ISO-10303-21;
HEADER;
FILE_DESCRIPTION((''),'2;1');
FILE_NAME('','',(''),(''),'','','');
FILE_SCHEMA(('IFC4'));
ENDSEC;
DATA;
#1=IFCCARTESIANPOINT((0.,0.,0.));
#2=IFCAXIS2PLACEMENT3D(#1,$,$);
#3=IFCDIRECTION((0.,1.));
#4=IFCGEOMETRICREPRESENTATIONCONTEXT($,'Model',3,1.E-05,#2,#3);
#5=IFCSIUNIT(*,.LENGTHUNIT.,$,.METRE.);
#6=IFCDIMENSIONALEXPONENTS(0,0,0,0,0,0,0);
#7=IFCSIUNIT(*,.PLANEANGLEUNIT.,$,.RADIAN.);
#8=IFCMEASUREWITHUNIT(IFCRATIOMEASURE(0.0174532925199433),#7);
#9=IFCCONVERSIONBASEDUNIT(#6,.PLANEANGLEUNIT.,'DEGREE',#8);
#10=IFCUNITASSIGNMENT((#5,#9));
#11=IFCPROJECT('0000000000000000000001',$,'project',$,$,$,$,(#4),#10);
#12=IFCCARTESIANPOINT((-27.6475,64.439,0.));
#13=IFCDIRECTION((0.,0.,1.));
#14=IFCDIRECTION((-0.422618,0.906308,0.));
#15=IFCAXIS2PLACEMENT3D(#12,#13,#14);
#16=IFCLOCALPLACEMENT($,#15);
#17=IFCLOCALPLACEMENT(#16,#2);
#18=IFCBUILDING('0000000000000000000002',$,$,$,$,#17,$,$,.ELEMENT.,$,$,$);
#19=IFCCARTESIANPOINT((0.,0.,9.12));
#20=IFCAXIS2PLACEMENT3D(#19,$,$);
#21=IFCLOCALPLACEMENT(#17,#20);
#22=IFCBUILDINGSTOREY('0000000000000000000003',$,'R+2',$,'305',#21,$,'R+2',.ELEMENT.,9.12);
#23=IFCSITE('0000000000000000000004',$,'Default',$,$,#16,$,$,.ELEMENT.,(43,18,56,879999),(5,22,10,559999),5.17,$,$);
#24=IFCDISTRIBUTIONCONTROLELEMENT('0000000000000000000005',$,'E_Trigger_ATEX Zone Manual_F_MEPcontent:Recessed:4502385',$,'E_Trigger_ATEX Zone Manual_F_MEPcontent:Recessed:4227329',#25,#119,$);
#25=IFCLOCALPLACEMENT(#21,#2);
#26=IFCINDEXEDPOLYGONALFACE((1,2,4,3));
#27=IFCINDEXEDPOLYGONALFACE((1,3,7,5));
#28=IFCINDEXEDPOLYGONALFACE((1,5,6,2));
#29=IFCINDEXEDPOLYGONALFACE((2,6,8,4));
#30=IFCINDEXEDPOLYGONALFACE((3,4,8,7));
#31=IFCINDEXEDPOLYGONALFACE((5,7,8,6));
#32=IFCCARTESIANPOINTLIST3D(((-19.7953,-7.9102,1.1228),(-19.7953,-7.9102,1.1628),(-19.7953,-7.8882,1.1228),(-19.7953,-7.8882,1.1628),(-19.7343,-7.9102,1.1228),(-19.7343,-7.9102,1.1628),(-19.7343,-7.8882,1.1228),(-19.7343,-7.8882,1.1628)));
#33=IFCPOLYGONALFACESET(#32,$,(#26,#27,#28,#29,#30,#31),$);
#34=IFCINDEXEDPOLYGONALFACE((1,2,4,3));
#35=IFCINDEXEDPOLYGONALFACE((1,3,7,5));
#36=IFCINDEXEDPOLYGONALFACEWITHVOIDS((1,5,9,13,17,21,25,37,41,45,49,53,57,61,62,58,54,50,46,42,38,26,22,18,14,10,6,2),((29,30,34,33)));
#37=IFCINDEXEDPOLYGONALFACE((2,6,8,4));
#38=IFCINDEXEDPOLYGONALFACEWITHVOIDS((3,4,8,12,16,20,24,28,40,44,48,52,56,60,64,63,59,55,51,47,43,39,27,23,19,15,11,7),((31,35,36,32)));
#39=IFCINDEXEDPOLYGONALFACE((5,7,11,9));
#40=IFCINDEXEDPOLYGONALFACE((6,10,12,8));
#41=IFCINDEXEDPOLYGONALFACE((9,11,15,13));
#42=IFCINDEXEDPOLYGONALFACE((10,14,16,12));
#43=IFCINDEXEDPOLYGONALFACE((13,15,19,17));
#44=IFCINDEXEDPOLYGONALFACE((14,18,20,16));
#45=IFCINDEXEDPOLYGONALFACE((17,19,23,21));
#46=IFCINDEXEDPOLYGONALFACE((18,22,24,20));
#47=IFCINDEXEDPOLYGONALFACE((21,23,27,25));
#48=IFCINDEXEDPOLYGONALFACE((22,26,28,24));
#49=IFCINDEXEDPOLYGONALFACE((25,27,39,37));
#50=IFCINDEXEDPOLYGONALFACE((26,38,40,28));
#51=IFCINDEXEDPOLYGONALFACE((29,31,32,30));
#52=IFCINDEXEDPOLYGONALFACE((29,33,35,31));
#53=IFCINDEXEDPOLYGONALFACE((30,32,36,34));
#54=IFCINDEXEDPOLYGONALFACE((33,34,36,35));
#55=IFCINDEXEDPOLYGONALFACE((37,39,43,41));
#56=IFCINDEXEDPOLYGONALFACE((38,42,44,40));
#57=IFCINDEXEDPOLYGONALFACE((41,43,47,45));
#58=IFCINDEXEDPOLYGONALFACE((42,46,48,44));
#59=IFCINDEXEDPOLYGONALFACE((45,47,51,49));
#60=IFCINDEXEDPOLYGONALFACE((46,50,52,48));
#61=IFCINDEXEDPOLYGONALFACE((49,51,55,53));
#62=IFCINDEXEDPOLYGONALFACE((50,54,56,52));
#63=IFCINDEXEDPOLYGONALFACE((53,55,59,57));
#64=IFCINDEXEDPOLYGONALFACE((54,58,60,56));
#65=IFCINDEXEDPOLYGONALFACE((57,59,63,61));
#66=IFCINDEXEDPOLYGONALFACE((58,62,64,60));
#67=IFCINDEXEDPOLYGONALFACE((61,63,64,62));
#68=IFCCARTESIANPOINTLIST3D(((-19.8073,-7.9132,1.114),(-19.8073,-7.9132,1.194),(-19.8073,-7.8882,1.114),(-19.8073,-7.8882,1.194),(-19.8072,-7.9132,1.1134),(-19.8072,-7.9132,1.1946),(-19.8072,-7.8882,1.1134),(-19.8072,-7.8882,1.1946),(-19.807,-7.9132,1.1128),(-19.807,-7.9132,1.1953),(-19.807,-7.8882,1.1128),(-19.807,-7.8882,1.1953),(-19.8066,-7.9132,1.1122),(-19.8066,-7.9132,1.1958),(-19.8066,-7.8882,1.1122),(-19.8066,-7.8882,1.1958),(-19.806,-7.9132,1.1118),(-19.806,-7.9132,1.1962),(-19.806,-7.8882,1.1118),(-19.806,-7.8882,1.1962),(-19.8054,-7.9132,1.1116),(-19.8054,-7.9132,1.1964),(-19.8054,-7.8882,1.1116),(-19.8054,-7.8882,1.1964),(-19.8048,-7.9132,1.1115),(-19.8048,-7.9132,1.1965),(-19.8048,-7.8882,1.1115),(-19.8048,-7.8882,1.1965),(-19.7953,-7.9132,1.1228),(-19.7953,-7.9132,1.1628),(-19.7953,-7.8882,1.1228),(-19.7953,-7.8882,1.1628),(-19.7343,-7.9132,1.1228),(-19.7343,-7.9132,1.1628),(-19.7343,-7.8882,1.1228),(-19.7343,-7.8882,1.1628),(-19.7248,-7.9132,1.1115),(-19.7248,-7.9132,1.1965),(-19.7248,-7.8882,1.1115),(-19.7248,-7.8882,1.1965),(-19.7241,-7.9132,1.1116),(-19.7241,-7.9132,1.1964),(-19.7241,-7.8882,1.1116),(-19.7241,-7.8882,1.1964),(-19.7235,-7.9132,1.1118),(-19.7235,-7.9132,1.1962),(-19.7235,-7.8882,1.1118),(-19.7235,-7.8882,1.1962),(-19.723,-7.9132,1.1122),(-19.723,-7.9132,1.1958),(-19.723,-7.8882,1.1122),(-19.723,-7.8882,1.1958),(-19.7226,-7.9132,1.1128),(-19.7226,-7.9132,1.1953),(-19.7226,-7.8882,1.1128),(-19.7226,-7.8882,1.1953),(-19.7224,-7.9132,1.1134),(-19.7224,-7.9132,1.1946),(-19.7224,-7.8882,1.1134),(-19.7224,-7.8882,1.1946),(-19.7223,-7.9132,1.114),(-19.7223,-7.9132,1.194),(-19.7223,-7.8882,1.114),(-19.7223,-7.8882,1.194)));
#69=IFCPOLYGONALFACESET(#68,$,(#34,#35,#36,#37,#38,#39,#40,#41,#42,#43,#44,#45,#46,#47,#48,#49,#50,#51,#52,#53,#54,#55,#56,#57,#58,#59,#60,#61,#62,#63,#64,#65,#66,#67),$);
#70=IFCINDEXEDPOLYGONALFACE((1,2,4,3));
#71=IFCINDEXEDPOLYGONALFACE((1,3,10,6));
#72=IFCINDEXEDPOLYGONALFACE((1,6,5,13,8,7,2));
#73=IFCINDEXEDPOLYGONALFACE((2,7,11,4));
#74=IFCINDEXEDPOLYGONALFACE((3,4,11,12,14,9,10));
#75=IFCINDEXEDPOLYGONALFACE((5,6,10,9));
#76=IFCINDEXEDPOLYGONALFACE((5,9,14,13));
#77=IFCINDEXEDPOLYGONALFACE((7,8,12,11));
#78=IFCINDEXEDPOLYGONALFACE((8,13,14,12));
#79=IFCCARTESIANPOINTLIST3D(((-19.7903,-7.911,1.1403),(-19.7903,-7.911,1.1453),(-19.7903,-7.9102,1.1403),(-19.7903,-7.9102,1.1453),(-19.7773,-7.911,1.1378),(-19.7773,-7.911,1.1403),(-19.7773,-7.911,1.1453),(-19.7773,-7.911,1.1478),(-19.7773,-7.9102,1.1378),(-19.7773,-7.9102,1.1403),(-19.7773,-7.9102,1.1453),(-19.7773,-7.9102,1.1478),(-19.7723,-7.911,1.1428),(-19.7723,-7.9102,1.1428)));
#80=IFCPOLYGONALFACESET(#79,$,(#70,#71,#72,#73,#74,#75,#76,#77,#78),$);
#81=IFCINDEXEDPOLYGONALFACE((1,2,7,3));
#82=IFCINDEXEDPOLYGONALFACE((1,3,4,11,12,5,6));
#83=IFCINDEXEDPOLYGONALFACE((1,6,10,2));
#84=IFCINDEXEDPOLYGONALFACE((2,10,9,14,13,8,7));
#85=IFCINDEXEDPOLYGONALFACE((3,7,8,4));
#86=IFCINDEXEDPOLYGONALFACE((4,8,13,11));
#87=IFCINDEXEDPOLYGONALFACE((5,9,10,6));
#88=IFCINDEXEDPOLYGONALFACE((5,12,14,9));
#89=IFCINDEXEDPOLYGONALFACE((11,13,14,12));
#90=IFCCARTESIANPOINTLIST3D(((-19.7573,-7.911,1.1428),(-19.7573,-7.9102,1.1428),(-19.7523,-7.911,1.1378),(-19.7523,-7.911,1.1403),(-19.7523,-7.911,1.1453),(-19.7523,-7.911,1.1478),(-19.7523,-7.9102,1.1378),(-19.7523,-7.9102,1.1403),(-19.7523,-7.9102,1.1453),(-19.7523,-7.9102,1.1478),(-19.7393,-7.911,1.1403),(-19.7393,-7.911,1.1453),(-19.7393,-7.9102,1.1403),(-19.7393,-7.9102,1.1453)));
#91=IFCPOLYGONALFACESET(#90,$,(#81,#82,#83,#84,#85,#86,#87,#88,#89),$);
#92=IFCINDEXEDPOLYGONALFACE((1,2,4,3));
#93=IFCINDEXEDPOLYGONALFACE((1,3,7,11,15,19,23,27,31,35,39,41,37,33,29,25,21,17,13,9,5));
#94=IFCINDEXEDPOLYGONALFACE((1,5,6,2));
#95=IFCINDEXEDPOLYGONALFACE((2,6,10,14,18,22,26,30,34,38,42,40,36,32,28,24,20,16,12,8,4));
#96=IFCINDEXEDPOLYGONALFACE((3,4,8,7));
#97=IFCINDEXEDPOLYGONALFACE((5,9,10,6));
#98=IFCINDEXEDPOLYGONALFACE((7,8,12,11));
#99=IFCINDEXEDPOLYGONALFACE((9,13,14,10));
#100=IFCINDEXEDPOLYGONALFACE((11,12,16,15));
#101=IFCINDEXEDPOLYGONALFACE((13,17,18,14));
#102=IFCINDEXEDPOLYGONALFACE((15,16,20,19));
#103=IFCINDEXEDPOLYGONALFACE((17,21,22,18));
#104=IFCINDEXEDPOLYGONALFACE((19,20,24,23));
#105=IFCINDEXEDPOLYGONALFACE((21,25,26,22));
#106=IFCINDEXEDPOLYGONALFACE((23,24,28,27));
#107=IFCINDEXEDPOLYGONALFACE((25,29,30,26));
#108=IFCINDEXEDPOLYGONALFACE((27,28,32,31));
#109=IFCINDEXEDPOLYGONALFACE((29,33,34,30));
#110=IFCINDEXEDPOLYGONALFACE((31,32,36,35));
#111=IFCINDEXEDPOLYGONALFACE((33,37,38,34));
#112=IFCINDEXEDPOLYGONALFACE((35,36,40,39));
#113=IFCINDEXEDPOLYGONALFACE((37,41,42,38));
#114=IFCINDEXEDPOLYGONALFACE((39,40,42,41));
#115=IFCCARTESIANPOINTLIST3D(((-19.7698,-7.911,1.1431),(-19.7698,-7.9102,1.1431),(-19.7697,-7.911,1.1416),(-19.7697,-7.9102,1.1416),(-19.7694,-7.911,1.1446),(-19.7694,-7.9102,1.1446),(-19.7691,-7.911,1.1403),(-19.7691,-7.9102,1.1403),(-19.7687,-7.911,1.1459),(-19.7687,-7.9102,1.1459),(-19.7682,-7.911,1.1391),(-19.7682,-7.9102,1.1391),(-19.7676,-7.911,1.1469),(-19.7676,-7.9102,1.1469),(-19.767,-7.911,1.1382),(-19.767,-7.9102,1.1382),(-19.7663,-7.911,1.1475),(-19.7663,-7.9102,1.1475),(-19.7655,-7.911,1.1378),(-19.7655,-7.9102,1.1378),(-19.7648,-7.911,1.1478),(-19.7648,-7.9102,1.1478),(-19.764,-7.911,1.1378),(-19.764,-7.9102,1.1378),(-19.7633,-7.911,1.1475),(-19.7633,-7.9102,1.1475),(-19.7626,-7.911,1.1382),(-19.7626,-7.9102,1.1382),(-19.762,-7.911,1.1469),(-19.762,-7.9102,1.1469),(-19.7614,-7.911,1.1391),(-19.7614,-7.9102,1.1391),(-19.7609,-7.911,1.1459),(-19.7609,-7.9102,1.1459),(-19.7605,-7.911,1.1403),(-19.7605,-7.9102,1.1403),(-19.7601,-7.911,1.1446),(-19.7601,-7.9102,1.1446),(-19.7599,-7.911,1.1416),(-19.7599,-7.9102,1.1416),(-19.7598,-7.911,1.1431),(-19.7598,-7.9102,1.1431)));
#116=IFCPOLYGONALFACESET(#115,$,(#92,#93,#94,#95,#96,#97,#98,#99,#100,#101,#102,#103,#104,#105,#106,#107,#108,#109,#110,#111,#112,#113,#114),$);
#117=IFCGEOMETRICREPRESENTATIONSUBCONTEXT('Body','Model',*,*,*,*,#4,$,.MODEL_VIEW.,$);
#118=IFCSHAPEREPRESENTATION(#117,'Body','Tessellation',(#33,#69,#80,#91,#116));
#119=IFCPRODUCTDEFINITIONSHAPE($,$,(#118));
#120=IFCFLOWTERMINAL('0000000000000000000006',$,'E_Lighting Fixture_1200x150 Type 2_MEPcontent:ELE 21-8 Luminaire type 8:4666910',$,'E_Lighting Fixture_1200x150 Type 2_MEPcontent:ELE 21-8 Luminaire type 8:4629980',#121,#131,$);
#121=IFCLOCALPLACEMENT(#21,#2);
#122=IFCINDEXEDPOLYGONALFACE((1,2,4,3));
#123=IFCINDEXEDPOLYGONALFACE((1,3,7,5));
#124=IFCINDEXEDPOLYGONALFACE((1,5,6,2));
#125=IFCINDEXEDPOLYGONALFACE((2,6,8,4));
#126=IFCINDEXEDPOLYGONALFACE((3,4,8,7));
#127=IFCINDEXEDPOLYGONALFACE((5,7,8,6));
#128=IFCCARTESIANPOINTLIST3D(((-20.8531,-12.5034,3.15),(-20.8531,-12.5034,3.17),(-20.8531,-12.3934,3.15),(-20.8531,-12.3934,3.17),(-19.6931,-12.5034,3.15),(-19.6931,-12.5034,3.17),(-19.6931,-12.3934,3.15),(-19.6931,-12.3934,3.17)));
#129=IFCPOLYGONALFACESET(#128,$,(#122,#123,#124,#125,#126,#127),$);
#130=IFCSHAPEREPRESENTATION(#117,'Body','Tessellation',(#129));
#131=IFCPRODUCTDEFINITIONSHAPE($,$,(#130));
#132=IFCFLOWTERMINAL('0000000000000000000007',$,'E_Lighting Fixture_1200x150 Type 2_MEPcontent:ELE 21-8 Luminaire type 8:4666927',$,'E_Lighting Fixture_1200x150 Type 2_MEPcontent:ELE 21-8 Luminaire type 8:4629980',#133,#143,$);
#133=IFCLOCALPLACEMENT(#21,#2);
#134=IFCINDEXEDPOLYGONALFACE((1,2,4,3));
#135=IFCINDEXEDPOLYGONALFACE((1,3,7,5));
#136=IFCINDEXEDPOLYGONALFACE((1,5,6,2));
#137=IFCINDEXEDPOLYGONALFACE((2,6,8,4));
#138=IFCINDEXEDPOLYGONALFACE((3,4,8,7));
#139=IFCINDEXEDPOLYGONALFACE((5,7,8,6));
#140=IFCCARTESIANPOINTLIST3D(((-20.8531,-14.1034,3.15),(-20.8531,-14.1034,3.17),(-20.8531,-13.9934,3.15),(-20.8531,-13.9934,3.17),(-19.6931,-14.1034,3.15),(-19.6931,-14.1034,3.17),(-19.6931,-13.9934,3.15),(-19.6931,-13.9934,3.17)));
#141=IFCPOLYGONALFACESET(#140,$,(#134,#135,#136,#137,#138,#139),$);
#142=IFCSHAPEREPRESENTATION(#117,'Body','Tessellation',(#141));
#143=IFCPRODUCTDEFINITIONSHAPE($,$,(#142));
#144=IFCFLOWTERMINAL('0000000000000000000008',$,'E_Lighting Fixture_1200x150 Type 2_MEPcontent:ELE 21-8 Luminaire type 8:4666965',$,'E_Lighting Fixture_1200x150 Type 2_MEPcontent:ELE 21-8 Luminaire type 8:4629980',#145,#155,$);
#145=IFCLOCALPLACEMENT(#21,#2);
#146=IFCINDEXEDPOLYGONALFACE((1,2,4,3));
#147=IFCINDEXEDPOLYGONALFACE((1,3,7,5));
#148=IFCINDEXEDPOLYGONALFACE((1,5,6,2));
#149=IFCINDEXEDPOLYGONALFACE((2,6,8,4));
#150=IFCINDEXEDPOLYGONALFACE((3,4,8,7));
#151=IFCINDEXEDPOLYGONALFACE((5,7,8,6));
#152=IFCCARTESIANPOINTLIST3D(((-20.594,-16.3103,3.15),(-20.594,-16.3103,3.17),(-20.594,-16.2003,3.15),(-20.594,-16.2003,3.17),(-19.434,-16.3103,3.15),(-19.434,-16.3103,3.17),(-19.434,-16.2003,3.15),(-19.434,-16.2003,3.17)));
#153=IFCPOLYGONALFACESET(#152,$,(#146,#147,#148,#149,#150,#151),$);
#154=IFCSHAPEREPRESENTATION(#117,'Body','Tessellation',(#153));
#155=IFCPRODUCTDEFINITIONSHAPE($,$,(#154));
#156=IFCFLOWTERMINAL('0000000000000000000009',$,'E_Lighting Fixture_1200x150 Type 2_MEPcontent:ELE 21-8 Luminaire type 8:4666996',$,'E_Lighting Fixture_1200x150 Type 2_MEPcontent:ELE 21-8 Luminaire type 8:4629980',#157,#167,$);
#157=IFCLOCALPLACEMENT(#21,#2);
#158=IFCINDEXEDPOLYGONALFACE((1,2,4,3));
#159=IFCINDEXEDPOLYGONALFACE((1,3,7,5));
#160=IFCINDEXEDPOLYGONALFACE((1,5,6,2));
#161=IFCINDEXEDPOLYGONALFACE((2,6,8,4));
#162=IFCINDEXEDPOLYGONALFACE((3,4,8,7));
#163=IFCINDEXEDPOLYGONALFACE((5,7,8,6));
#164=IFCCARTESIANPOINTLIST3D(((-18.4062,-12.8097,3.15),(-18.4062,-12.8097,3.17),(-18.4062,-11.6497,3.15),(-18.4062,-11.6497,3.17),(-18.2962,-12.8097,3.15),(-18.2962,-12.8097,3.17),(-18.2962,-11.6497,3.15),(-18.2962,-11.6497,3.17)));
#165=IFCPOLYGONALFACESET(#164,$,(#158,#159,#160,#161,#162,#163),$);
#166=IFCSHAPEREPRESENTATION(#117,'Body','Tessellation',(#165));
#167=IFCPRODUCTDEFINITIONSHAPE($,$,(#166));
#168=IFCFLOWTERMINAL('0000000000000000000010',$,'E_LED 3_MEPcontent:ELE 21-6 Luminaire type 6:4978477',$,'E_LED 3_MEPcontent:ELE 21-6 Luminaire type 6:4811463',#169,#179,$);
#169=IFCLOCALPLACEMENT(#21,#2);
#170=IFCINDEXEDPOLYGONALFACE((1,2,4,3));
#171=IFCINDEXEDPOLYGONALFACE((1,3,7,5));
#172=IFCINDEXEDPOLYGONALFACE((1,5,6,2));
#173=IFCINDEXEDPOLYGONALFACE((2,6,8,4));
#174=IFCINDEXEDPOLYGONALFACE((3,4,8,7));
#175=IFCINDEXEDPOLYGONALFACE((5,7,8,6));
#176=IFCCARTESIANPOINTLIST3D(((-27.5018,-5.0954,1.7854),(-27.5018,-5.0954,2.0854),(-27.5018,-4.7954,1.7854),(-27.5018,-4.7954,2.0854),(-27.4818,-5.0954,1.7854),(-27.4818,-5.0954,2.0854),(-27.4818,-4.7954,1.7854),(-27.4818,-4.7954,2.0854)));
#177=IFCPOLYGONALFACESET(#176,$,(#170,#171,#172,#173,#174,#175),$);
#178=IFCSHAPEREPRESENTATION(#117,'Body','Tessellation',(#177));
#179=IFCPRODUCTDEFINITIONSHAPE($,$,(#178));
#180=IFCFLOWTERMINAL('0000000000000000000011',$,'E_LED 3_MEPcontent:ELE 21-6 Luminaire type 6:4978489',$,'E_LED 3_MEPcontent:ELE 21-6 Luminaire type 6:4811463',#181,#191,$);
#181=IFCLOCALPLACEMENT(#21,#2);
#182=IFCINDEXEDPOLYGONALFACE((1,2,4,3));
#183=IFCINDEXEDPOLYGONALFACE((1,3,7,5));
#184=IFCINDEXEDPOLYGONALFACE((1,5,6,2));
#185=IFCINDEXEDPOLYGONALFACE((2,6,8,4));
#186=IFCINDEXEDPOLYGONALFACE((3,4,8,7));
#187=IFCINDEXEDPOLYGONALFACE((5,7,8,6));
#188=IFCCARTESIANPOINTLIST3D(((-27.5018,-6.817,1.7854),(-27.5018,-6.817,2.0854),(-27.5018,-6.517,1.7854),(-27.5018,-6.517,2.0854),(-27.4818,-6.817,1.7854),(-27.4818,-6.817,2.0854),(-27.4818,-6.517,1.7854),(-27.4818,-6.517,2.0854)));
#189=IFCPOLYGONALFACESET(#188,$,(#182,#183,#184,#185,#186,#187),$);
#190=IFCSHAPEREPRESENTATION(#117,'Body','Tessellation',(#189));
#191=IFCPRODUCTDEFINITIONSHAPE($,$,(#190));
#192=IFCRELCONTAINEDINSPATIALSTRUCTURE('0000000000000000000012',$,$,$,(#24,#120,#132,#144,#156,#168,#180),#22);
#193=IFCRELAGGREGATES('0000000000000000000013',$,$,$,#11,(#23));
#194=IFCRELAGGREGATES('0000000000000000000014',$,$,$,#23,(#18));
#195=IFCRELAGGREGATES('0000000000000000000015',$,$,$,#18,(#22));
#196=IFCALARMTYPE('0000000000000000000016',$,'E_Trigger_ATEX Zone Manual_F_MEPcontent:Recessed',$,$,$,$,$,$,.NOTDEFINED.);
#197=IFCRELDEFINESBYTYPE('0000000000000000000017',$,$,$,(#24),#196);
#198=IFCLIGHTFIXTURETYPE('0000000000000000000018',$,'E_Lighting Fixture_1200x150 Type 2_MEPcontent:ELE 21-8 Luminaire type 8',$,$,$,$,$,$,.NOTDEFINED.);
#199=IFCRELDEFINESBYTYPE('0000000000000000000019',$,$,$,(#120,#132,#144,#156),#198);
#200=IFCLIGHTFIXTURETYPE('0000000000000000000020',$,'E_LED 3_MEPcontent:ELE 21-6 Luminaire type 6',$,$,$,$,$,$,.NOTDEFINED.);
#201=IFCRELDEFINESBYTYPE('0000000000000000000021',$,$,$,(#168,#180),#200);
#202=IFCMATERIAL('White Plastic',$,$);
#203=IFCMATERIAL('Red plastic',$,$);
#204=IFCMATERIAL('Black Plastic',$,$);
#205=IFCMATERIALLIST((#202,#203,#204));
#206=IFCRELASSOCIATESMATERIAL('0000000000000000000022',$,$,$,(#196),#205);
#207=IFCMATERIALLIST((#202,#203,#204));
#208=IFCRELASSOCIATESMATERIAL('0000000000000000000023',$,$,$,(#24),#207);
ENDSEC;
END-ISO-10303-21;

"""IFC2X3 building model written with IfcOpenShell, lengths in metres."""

from ifc_helpers import new_model, entity, si_unit, converted_unit, direction, frame, frame_2d, origin, origin_2d_with_axis, place, context, subcontext, project, spatial, polyline, circle_curve, parameter, trimmed, segment, composite_curve, rectangle, circle, outline, extrude, source, transform, mapped, material, material_list, type_object, type_shapes, element, save


model = new_model("IFC2X3")

# Units and contexts
model_context = context("Model", 3, precision=1e-05, world=origin(), true_north=direction((0.0, 1.0)))
body_context = subcontext(model_context, "Body", "Model", "MODEL_VIEW")
ifc_project = project(units=[si_unit("LENGTHUNIT", "METRE"), converted_unit("PLANEANGLEUNIT", "DEGREE", entity("IfcRatioMeasure", 0.0174532925199433), si_unit("PLANEANGLEUNIT", "RADIAN"), dimensions=[0, 0, 0, 0, 0, 0, 0])], contexts=[model_context])

# Site, building, storey
site_placement = place(None, frame((-27.6475, 64.439, 0.0), z_axis=(0.0, 0.0, 1.0), x_axis=(-0.422618, 0.906308, 0.0)))
site = spatial("IfcSite", under=ifc_project, at=site_placement, Name="Default", CompositionType="ELEMENT", RefLatitude=(43, 18, 56, 879999), RefLongitude=(5, 22, 10, 559999), RefElevation=5.17)
building_placement = place(site_placement, origin())
building = spatial("IfcBuilding", under=site, at=building_placement, CompositionType="ELEMENT")
storey_placement = place(building_placement, frame((0.0, 0.0, 9.12)))
storey = spatial("IfcBuildingStorey", under=building, at=storey_placement, Name="R+2", ObjectType="305", LongName="R+2", CompositionType="ELEMENT", Elevation=9.12)

# Distribution control element
ifc_material_1 = material(Name="White Plastic")
ifc_material_2 = material(Name="Red plastic")
ifc_material_3 = material(Name="Black Plastic")
ifc_material_list_1 = material_list([ifc_material_1, ifc_material_2, ifc_material_3])
ifc_material_list_2 = material_list([ifc_material_1, ifc_material_2, ifc_material_3])
alarm_type_1 = type_object("IfcAlarmType", Name="E_Trigger_ATEX Zone Manual_F_MEPcontent:Recessed", PredefinedType="NOTDEFINED", material=ifc_material_list_2)
shared_shape_1 = source(origin(), body_context, "Body", "SweptSolid", [
    extrude(rectangle(XDim=0.061, YDim=0.04, at=origin_2d_with_axis()), frame((0.0, -0.0112, 0.0), z_axis=(0.0, 0.0, 1.0), x_axis=(-1.0, 0.0, 0.0)), (0.0, 0.0, 1.0), 0.022),
    extrude(outline(composite_curve([segment(polyline([(-0.04, -0.0425), (0.04, -0.0425)]), True, "CONTINUOUS"), segment(trimmed(circle_curve(frame_2d((0.04, -0.04), x_axis=(-1.0, 0.0)), 0.0025), [parameter(90.0)], [parameter(180.0)], True, "PARAMETER"), True, "CONTINUOUS"), segment(polyline([(0.0425, -0.04), (0.0425, 0.04)]), True, "CONTINUOUS"), segment(trimmed(circle_curve(frame_2d((0.04, 0.04), x_axis=(-1.0, 0.0)), 0.0025), [parameter(180.0)], [parameter(270.0)], True, "PARAMETER"), True, "CONTINUOUS"), segment(polyline([(0.04, 0.0425), (-0.04, 0.0425)]), True, "CONTINUOUS"), segment(trimmed(circle_curve(frame_2d((-0.04, 0.04), x_axis=(-1.0, 0.0)), 0.0025), [parameter(270.0)], [parameter(0.0)], True, "PARAMETER"), True, "CONTINUOUS"), segment(polyline([(-0.0425, 0.04), (-0.0425, -0.04)]), True, "CONTINUOUS"), segment(trimmed(circle_curve(frame_2d((-0.04, -0.04), x_axis=(-1.0, 0.0)), 0.0025), [parameter(360.0)], [parameter(90.0)], True, "PARAMETER"), True, "CONTINUOUS")], self_intersect=False), holes=[polyline([(-0.0305, -0.0088), (-0.0305, 0.0312), (0.0305, 0.0312), (0.0305, -0.0088), (-0.0305, -0.0088)])]), frame((0.0, 0.0, 0.0), z_axis=(0.0, 0.0, 1.0), x_axis=(-1.0, 0.0, 0.0)), (0.0, 0.0, 1.0), 0.025),
    extrude(outline(polyline([(-0.01, 0.0025), (-0.01, -0.0025), (0.003, -0.0025), (0.003, -0.005), (0.008, 0.0), (0.003, 0.005), (0.003, 0.0025), (-0.01, 0.0025)])), frame((-0.0155, -0.0112, 0.022), z_axis=(0.0, 0.0, -1.0), x_axis=(1.0, 0.0, 0.0)), (0.0, 0.0, -1.0), 0.0008),
    extrude(outline(polyline([(-0.0014, -0.0057), (0.0057, -0.0057), (0.0057, 0.0014), (0.0039, -0.0004), (-0.0053, 0.0088), (-0.0088, 0.0053), (0.0004, -0.0039), (-0.0014, -0.0057)])), frame((0.0155, -0.0112, 0.022), z_axis=(0.0, 0.0, 1.0), x_axis=(-0.707107, -0.707107, 0.0)), (0.0, 0.0, 1.0), 0.0008),
    extrude(circle(Radius=0.005, at=frame_2d((0.0, 0.0), x_axis=(1.0, 0.0))), frame((0.0, -0.0112, 0.022), z_axis=(0.0, 0.0, 1.0), x_axis=(0.0, 1.0, 0.0)), (0.0, 0.0, 1.0), 0.0008),
])
type_shapes(alarm_type_1, [shared_shape_1])
distribution_control_element_1_placement = place(storey_placement, frame((-19.7648, -7.8882, 1.154), z_axis=(0.0, -1.0, 0.0), x_axis=(1.0, 0.0, 0.0)))
element("IfcDistributionControlElement", 1, at=distribution_control_element_1_placement, inside=storey, type_object=alarm_type_1, material=ifc_material_list_1, Name="E_Trigger_ATEX Zone Manual_F_MEPcontent:Recessed:4502385", ObjectType="E_Trigger_ATEX Zone Manual_F_MEPcontent:Recessed:4227329", context=body_context, shape_type="MappedRepresentation", body=[
    mapped(shared_shape_1, transform((0.0, 0.0, 0.0), scale=1.0)),
])

# Flow terminals
light_fixture_type_1 = type_object("IfcLightFixtureType", Name="E_Lighting Fixture_1200x150 Type 2_MEPcontent:ELE 21-8 Luminaire type 8", PredefinedType="NOTDEFINED")
shared_shape_2 = source(origin(), body_context, "Body", "SweptSolid", [
    extrude(rectangle(XDim=0.11, YDim=1.16, at=origin_2d_with_axis()), frame((0.0, 0.0, 0.0), z_axis=(0.0, 0.0, 1.0), x_axis=(0.0, -1.0, 0.0)), (0.0, 0.0, 1.0), 0.02),
])
type_shapes(light_fixture_type_1, [shared_shape_2])
for number, where, name in (
    (2, (-20.2731, -12.4484, 3.15), "E_Lighting Fixture_1200x150 Type 2_MEPcontent:ELE 21-8 Luminaire type 8:4666910"),
    (3, (-20.2731, -14.0484, 3.15), "E_Lighting Fixture_1200x150 Type 2_MEPcontent:ELE 21-8 Luminaire type 8:4666927"),
    (4, (-20.014, -16.2553, 3.15), "E_Lighting Fixture_1200x150 Type 2_MEPcontent:ELE 21-8 Luminaire type 8:4666965"),
):
    element("IfcFlowTerminal", number, at=place(storey_placement, frame(where)), inside=storey, type_object=light_fixture_type_1, Name=name, ObjectType="E_Lighting Fixture_1200x150 Type 2_MEPcontent:ELE 21-8 Luminaire type 8:4629980", context=body_context, shape_type="MappedRepresentation", body=[
        mapped(shared_shape_2, transform((0.0, 0.0, 0.0), scale=1.0)),
    ])
flow_terminal_1_placement = place(storey_placement, frame((-18.3512, -12.2297, 3.15), z_axis=(0.0, 0.0, 1.0), x_axis=(0.0, -1.0, 0.0)))
element("IfcFlowTerminal", 5, at=flow_terminal_1_placement, inside=storey, type_object=light_fixture_type_1, Name="E_Lighting Fixture_1200x150 Type 2_MEPcontent:ELE 21-8 Luminaire type 8:4666996", ObjectType="E_Lighting Fixture_1200x150 Type 2_MEPcontent:ELE 21-8 Luminaire type 8:4629980", context=body_context, shape_type="MappedRepresentation", body=[
    mapped(shared_shape_2, transform((0.0, 0.0, 0.0), scale=1.0)),
])
light_fixture_type_2 = type_object("IfcLightFixtureType", Name="E_LED 3_MEPcontent:ELE 21-6 Luminaire type 6", PredefinedType="NOTDEFINED")
shared_shape_3 = source(origin(), body_context, "Body", "SweptSolid", [
    extrude(rectangle(XDim=0.02, YDim=0.3, at=origin_2d_with_axis()), frame((0.0, 0.01, -0.15), z_axis=(0.0, 0.0, 1.0), x_axis=(0.0, -1.0, 0.0)), (0.0, 0.0, 1.0), 0.3),
])
type_shapes(light_fixture_type_2, [shared_shape_3])
for number, where, z_axis, x_axis, name in (
    (6, (-27.5018, -4.9454, 1.9354), (0.0, 0.0, 1.0), (0.0, -1.0, 0.0), "E_LED 3_MEPcontent:ELE 21-6 Luminaire type 6:4978477"),
    (7, (-27.5018, -6.667, 1.9354), (0.0, 0.0, 1.0), (0.0, -1.0, 0.0), "E_LED 3_MEPcontent:ELE 21-6 Luminaire type 6:4978489"),
):
    element("IfcFlowTerminal", number, at=place(storey_placement, frame(where, z_axis=z_axis, x_axis=x_axis)), inside=storey, type_object=light_fixture_type_2, Name=name, ObjectType="E_LED 3_MEPcontent:ELE 21-6 Luminaire type 6:4811463", context=body_context, shape_type="MappedRepresentation", body=[
        mapped(shared_shape_3, transform((0.0, 0.0, 0.0), scale=1.0)),
    ])

save(model, "model.ifc")
